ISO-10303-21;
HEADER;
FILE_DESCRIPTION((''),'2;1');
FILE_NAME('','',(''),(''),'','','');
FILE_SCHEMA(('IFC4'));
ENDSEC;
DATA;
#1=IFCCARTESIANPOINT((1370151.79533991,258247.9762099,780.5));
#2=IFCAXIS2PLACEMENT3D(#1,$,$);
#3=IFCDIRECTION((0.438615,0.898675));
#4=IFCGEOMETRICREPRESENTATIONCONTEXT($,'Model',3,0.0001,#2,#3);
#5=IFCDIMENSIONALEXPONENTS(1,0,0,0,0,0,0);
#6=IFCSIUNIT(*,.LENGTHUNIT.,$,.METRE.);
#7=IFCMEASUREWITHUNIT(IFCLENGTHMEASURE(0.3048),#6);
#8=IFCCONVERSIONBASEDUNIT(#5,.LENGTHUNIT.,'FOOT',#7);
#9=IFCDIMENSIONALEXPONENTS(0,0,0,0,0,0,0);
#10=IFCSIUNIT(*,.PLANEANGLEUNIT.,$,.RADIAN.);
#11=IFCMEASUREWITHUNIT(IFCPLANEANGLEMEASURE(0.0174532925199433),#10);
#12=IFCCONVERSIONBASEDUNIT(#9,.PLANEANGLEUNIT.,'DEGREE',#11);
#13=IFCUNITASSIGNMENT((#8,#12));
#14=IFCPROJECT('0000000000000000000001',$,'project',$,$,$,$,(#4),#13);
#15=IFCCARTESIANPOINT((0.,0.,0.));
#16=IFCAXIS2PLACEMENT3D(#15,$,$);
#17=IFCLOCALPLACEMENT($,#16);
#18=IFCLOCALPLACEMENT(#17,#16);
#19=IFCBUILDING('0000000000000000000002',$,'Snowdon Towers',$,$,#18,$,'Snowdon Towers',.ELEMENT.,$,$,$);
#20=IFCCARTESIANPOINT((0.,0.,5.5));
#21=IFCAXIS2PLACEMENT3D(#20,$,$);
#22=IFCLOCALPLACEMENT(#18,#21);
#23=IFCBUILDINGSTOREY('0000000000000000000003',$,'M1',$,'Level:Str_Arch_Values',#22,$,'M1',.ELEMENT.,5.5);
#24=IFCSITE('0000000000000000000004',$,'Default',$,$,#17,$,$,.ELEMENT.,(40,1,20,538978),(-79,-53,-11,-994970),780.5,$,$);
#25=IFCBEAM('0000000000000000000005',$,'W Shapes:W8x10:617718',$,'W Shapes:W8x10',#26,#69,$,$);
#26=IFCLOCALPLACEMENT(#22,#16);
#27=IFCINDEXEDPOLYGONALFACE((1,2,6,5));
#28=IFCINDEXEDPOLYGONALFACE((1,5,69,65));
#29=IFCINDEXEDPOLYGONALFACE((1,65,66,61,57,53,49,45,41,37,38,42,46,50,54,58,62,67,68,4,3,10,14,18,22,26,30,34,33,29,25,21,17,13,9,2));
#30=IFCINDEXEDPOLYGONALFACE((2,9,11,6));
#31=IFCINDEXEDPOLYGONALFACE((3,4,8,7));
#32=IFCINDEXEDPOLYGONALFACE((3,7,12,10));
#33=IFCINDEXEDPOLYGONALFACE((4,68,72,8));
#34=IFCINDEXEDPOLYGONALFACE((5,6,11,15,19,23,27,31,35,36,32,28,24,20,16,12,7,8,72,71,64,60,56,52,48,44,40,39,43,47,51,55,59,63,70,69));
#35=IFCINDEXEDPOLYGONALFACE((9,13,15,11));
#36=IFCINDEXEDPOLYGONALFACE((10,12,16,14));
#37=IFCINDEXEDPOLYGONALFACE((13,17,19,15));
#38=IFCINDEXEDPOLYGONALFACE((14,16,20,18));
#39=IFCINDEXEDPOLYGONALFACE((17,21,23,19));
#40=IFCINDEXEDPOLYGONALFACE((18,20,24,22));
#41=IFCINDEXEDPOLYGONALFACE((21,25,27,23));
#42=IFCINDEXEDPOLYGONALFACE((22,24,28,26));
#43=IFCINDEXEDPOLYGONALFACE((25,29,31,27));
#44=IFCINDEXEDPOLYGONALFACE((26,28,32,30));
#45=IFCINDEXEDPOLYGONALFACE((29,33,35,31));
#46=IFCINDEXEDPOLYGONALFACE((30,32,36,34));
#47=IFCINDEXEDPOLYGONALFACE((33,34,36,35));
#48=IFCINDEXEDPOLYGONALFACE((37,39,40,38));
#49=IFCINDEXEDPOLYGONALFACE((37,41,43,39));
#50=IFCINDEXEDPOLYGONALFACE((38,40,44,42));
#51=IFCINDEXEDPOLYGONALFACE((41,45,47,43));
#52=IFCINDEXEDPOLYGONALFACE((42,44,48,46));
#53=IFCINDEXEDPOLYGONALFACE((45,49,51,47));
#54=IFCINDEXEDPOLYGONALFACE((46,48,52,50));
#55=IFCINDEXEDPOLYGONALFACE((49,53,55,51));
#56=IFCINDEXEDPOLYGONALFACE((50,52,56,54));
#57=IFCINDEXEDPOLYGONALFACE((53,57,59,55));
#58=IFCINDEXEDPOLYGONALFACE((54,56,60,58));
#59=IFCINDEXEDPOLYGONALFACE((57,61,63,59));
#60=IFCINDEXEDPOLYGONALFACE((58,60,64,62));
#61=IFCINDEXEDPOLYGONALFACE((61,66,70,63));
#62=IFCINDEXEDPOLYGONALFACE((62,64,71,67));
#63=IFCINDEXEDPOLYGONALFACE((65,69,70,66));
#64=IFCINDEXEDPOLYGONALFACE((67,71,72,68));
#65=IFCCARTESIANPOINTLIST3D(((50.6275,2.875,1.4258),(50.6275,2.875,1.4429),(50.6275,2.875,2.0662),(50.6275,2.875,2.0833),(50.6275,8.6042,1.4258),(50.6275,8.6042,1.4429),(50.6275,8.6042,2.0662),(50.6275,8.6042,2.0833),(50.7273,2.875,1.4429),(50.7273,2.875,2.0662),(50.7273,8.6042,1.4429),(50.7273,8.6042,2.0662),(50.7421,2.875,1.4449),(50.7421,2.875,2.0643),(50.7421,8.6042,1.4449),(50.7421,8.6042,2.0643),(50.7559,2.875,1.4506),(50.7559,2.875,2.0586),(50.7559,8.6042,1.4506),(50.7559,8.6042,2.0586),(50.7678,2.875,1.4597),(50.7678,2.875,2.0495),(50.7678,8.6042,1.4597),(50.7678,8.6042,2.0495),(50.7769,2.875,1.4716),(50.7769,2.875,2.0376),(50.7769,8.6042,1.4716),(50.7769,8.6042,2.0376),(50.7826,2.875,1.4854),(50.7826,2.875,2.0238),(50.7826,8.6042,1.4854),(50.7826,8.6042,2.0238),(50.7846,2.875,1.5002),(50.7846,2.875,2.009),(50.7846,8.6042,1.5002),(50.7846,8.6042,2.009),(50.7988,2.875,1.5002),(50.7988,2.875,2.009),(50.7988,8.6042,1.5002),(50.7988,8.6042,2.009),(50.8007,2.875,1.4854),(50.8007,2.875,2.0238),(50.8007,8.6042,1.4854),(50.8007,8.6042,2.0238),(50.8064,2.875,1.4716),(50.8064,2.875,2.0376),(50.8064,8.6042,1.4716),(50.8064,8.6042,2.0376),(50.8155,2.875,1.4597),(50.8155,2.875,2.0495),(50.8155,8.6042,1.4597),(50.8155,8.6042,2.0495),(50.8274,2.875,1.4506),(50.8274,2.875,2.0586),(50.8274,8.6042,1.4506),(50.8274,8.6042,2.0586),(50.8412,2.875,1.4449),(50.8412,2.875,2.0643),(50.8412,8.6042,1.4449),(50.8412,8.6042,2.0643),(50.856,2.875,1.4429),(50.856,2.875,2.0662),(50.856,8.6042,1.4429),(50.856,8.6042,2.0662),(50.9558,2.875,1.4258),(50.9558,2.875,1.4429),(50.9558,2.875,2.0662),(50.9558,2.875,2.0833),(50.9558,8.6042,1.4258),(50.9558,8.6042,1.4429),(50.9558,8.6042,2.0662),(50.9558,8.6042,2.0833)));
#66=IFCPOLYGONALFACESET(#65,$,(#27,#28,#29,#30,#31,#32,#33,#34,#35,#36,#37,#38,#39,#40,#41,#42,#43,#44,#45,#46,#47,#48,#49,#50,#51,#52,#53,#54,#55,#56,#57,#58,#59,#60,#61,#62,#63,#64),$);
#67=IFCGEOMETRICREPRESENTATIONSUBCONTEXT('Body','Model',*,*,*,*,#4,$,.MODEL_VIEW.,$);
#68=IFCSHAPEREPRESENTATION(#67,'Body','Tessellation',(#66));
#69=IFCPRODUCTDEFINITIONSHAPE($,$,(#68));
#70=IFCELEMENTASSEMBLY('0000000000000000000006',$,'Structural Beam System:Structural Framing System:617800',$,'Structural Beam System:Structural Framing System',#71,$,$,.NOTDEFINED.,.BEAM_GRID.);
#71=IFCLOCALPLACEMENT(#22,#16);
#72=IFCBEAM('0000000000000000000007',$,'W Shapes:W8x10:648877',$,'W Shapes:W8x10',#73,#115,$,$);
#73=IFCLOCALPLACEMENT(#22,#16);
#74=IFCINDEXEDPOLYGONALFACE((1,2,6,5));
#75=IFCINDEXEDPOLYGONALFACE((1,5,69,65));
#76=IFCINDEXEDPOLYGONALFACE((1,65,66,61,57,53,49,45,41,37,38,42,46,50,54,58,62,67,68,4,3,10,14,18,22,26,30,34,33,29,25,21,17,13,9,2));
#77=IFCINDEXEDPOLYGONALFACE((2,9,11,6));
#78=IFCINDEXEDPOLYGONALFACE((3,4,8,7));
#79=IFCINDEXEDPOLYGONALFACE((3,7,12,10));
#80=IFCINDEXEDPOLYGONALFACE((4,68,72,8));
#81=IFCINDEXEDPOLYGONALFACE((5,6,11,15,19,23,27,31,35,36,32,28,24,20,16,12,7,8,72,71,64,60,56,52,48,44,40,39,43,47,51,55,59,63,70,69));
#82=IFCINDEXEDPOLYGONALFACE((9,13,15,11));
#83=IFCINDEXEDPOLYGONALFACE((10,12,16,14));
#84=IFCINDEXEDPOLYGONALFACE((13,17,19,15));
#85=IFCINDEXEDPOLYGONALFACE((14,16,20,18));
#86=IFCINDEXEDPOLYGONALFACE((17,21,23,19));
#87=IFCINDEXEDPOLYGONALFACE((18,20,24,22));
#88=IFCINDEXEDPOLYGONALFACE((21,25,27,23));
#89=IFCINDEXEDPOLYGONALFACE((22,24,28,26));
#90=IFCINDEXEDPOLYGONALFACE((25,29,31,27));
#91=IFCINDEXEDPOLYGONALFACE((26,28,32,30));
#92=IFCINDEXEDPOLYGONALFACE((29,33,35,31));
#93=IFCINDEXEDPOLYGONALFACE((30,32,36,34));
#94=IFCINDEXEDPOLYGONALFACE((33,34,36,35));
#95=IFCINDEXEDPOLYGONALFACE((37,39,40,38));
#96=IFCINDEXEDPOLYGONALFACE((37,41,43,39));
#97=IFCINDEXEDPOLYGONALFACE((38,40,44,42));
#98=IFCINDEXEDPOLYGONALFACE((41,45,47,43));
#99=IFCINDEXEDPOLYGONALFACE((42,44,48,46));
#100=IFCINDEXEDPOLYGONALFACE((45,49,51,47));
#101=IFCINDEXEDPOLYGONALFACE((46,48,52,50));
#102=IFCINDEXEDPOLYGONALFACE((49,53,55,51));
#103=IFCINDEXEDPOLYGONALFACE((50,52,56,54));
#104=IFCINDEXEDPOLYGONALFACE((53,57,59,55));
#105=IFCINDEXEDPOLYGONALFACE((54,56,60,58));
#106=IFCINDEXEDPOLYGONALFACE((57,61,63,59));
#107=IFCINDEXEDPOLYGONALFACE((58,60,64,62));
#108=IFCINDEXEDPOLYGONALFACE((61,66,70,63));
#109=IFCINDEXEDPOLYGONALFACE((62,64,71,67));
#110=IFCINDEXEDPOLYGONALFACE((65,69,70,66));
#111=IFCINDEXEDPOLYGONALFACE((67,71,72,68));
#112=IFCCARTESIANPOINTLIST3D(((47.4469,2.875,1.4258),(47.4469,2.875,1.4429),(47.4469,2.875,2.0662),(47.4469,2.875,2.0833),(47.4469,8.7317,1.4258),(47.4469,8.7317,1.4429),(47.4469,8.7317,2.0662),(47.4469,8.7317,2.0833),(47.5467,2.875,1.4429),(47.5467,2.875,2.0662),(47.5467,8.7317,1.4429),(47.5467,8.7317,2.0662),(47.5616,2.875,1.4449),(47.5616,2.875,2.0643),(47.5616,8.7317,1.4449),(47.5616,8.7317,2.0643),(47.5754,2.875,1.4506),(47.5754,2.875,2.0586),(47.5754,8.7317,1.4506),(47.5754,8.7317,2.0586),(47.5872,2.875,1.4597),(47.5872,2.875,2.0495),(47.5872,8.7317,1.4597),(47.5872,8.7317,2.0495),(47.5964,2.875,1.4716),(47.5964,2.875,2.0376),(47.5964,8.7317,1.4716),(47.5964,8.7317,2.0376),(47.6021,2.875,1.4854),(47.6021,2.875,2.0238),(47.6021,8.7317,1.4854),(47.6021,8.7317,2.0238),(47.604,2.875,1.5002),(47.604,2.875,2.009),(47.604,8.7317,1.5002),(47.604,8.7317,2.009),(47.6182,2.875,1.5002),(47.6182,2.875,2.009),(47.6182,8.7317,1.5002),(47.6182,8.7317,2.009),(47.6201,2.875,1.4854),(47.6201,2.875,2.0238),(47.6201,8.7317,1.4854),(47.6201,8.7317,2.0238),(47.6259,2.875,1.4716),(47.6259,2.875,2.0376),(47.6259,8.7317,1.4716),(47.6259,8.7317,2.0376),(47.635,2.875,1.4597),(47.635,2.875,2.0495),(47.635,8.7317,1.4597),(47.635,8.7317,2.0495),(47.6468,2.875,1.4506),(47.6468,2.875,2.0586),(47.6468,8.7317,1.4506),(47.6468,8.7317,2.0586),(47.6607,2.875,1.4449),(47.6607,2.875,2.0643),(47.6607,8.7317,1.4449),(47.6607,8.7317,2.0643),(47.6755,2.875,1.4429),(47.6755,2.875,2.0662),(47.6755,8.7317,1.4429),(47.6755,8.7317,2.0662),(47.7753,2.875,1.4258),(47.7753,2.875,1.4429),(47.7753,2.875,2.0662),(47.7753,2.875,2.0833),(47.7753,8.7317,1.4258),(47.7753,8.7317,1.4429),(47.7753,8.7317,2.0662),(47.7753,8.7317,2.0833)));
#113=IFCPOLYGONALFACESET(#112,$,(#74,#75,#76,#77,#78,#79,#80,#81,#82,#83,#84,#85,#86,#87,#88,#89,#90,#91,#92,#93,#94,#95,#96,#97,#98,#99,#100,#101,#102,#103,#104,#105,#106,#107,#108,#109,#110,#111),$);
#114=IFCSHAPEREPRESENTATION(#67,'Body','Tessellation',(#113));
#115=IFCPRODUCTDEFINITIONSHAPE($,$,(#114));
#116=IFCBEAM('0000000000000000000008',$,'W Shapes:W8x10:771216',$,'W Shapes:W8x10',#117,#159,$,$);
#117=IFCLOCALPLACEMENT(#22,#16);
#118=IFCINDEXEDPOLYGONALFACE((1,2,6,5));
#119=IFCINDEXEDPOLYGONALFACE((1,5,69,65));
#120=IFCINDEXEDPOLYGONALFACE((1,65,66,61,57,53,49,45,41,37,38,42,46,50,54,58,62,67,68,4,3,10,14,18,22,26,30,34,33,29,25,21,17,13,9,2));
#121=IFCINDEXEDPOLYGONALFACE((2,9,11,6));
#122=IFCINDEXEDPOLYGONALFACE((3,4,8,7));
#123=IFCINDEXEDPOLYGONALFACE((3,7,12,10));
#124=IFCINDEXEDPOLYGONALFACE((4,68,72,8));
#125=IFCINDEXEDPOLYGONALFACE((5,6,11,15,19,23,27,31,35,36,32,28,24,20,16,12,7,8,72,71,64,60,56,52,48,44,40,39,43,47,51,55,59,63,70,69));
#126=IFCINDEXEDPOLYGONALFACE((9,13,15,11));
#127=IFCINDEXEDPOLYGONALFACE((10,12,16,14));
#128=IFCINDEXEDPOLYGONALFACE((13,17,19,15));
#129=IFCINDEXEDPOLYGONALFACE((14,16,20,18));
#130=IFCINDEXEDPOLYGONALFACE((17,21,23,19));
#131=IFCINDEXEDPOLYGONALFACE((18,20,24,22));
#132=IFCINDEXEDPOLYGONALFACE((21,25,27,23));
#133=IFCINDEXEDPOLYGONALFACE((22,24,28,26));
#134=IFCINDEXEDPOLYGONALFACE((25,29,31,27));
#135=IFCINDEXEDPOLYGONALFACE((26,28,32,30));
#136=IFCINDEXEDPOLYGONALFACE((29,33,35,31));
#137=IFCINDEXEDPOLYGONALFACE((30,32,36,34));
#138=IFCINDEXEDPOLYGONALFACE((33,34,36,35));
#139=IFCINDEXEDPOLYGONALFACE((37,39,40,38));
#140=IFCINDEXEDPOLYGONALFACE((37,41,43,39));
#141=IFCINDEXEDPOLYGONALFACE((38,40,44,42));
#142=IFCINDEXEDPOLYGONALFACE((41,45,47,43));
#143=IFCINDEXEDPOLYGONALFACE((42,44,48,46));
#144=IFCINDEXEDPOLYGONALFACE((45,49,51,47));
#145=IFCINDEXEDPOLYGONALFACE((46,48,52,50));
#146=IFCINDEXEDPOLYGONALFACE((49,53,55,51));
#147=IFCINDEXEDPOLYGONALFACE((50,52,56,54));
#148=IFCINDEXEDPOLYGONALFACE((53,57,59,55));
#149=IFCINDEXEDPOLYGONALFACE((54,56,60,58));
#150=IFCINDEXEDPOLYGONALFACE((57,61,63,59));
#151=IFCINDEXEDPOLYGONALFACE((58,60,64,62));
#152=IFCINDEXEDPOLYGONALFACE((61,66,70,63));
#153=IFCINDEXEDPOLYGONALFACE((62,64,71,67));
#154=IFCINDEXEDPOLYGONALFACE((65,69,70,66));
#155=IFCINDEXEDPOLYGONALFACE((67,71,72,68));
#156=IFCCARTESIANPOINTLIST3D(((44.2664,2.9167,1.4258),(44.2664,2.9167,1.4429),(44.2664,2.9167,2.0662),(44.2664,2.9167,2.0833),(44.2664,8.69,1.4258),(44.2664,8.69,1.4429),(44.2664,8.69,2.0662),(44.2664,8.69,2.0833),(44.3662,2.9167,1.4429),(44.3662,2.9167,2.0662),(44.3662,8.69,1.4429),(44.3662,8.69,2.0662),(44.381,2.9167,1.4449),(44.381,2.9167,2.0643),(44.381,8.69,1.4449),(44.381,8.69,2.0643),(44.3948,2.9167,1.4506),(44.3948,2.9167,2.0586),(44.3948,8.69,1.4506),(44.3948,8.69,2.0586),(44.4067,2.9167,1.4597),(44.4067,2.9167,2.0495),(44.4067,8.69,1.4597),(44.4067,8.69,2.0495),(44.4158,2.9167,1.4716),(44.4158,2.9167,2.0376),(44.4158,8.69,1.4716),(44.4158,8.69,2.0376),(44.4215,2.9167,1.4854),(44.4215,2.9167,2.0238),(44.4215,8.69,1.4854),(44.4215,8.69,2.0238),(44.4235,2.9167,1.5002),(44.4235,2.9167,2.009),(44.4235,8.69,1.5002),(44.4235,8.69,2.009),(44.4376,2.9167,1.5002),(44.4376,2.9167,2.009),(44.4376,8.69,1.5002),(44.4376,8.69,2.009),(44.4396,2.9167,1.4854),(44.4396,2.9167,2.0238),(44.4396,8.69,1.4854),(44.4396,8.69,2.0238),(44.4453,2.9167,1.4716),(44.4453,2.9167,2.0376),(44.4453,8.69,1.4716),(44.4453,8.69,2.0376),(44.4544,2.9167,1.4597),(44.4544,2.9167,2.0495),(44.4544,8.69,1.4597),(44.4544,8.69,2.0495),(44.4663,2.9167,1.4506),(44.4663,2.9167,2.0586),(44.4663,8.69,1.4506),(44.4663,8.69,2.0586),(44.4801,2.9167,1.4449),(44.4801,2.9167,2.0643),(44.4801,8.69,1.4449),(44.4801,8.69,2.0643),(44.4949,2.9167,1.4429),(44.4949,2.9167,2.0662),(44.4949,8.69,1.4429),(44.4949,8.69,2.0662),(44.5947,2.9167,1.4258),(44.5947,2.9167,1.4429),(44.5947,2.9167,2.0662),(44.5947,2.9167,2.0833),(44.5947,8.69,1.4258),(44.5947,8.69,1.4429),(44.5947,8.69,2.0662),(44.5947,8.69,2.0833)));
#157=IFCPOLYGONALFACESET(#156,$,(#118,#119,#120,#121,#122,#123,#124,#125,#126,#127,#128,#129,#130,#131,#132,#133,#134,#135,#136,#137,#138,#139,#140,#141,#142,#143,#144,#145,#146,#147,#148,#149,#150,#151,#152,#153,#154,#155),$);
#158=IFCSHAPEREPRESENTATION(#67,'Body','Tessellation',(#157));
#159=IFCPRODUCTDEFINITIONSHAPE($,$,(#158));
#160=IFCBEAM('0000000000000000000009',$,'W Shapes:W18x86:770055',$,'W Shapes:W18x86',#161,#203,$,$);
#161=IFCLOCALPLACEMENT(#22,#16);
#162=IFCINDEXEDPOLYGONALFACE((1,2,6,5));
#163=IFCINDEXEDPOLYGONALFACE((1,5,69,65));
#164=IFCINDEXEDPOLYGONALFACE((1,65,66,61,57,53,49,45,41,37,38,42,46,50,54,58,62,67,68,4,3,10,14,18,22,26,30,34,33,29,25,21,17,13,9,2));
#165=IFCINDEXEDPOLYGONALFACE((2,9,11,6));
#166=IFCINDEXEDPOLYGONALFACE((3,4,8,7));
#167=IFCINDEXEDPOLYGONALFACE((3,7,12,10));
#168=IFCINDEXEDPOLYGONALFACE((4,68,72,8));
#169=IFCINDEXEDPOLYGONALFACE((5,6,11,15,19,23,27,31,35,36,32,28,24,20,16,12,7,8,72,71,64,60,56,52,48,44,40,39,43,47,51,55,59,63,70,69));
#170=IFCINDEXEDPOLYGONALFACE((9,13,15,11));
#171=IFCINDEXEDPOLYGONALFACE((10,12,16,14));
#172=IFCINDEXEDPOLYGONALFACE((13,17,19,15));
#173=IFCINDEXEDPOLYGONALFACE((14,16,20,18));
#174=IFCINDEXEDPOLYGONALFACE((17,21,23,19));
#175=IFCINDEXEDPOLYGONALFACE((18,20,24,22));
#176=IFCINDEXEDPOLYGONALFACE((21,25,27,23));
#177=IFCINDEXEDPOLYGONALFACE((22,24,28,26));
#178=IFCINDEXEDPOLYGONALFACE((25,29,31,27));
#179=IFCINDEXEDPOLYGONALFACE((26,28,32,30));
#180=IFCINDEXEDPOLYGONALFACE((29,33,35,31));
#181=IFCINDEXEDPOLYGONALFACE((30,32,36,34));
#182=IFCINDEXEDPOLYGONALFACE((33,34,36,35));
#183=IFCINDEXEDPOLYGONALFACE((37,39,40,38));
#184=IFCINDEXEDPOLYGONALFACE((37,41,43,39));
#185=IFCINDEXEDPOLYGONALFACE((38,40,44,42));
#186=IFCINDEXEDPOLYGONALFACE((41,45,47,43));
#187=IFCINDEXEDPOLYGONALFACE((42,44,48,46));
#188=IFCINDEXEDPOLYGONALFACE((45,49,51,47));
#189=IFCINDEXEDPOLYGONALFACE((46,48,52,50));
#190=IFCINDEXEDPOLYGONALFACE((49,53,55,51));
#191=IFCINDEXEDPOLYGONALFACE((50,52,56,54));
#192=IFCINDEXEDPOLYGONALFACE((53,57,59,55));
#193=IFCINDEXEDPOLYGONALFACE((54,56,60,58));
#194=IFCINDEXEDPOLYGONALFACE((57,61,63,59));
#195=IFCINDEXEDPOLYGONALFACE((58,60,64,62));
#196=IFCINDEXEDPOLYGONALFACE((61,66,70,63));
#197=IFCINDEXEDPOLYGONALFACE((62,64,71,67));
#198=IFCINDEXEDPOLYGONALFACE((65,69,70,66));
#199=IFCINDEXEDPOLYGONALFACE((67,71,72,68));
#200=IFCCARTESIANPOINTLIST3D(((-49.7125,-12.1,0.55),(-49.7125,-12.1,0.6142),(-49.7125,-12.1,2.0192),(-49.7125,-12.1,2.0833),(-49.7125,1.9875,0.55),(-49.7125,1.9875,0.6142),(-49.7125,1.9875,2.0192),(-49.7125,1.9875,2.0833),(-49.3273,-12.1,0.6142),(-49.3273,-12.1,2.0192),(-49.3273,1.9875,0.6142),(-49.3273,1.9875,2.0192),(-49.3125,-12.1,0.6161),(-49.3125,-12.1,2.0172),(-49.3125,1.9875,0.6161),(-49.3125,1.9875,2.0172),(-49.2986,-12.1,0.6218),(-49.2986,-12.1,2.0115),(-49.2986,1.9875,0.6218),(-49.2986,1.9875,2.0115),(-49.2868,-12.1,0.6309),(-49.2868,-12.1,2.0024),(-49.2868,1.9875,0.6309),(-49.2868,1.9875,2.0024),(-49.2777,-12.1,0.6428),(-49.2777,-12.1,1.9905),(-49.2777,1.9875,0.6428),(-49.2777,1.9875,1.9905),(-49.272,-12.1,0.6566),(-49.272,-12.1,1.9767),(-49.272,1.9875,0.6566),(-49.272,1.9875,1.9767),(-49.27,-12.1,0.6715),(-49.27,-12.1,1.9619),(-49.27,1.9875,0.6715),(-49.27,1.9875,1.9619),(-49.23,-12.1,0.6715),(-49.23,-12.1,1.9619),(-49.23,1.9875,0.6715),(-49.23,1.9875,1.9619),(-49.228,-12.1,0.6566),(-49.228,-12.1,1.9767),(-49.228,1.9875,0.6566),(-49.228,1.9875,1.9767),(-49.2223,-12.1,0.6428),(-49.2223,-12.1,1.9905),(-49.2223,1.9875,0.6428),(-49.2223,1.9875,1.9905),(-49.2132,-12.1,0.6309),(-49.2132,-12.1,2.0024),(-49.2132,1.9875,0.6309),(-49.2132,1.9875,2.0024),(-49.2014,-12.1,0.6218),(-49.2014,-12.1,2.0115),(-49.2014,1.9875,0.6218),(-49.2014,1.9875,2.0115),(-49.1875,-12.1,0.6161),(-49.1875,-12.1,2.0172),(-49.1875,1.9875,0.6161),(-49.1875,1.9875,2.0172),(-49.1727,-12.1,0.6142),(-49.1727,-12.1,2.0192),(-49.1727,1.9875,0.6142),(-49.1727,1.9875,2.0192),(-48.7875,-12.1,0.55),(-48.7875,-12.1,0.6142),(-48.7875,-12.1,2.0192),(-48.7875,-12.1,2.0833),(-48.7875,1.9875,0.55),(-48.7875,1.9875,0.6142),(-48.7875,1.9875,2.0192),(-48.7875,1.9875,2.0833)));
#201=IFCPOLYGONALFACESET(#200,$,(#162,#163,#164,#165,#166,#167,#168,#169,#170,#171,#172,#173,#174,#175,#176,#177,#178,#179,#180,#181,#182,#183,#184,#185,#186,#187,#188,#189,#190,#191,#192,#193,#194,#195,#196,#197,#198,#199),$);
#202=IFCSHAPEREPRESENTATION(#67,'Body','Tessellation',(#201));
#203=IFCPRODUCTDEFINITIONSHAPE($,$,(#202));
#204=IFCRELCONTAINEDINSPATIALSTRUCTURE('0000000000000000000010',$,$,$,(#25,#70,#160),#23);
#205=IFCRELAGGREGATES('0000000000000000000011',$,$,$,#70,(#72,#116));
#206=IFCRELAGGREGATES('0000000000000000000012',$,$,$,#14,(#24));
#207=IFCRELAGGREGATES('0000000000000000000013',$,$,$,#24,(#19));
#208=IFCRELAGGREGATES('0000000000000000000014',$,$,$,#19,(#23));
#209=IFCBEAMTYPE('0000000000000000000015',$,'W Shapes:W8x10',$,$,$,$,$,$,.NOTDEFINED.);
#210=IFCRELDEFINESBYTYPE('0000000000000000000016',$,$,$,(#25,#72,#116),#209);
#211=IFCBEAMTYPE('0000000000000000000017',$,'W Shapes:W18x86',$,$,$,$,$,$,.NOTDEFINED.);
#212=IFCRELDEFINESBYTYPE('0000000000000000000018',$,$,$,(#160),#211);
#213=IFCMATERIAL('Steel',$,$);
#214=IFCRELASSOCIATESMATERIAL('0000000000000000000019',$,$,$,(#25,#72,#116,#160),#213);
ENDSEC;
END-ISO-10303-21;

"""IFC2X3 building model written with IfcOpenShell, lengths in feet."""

from ifc_helpers import new_model, entity, si_unit, converted_unit, direction, frame, frame_2d, origin, place, context, subcontext, project, spatial, i_section, extrude, material, type_object, element, aggregate, save


model = new_model("IFC2X3")

# Units and contexts
model_context = context("Model", 3, precision=0.0001, world=frame((1370151.79533991, 258247.9762099, 780.5)), true_north=direction((0.438615, 0.898675)))
body_context = subcontext(model_context, "Body", "Model", "MODEL_VIEW")
ifc_project = project(units=[converted_unit("LENGTHUNIT", "FOOT", entity("IfcLengthMeasure", 0.3048), si_unit("LENGTHUNIT", "METRE"), dimensions=[1, 0, 0, 0, 0, 0, 0]), converted_unit("PLANEANGLEUNIT", "DEGREE", entity("IfcPlaneAngleMeasure", 0.0174532925199433), si_unit("PLANEANGLEUNIT", "RADIAN"), dimensions=[0, 0, 0, 0, 0, 0, 0])], contexts=[model_context])

# Site, building, storey
site_placement = place(None, origin())
site = spatial("IfcSite", under=ifc_project, at=site_placement, Name="Default", CompositionType="ELEMENT", RefLatitude=(40, 1, 20, 538978), RefLongitude=(-79, -53, -11, -994970), RefElevation=780.5)
building_placement = place(site_placement, origin())
building = spatial("IfcBuilding", under=site, at=building_placement, Name="Snowdon Towers", LongName="Snowdon Towers", CompositionType="ELEMENT")
storey_placement = place(building_placement, frame((0.0, 0.0, 5.5)))
storey = spatial("IfcBuildingStorey", under=building, at=storey_placement, Name="M1", ObjectType="Level:Str_Arch_Values", LongName="M1", CompositionType="ELEMENT", Elevation=5.5)

# Beam
ifc_material_1 = material(Name="Steel")
beam_type_1 = type_object("IfcBeamType", Name="W Shapes:W8x10", PredefinedType="NOTDEFINED")
beam_1_placement = place(storey_placement, frame((50.7917, 9.0, 2.0833), z_axis=(0.0, 0.0, 1.0), x_axis=(0.0, -1.0, 0.0)))
element("IfcBeam", 1, at=beam_1_placement, inside=storey, type_object=beam_type_1, material=ifc_material_1, Name="W Shapes:W8x10:617718", ObjectType="W Shapes:W8x10", context=body_context, shape_type="SweptSolid", body=[
    extrude(i_section(OverallWidth=0.3283, OverallDepth=0.6575, WebThickness=0.0142, FlangeThickness=0.0171, FilletRadius=0.0573, at=frame_2d((0.0, 0.0), x_axis=(0.0, 1.0))), frame((0.3958, 0.0, -0.3288), z_axis=(1.0, 0.0, 0.0), x_axis=(0.0, 0.0, -1.0)), (0.0, 0.0, 1.0), 5.7292),
])

# Element assembly, beams
assembly_placement = place(storey_placement, origin())
assembly = element("IfcElementAssembly", 2, at=assembly_placement, inside=storey, Name="Structural Beam System:Structural Framing System:617800", ObjectType="Structural Beam System:Structural Framing System", AssemblyPlace="NOTDEFINED", PredefinedType="BEAM_GRID")
beam_2_placement = place(assembly_placement, frame((47.6111, 8.8958, 2.0833), z_axis=(0.0, 0.0, 1.0), x_axis=(0.0, -1.0, 0.0)))
beam_2 = element("IfcBeam", 3, at=beam_2_placement, type_object=beam_type_1, material=ifc_material_1, Name="W Shapes:W8x10:648877", ObjectType="W Shapes:W8x10", context=body_context, shape_type="SweptSolid", body=[
    extrude(i_section(OverallWidth=0.3283, OverallDepth=0.6575, WebThickness=0.0142, FlangeThickness=0.0171, FilletRadius=0.0573, at=frame_2d((0.0, 0.0), x_axis=(0.0, 1.0))), frame((0.1642, 0.0, -0.3288), z_axis=(1.0, 0.0, 0.0), x_axis=(0.0, 0.0, -1.0)), (0.0, 0.0, 1.0), 5.8567),
])
beam_3_placement = place(assembly_placement, frame((44.4306, 8.8958, 2.0833), z_axis=(0.0, 0.0, 1.0), x_axis=(0.0, -1.0, 0.0)))
beam_3 = element("IfcBeam", 4, at=beam_3_placement, type_object=beam_type_1, material=ifc_material_1, Name="W Shapes:W8x10:771216", ObjectType="W Shapes:W8x10", context=body_context, shape_type="SweptSolid", body=[
    extrude(i_section(OverallWidth=0.3283, OverallDepth=0.6575, WebThickness=0.0142, FlangeThickness=0.0171, FilletRadius=0.0573, at=frame_2d((0.0, 0.0), x_axis=(0.0, 1.0))), frame((0.2058, 0.0, -0.3288), z_axis=(1.0, 0.0, 0.0), x_axis=(0.0, 0.0, -1.0)), (0.0, 0.0, 1.0), 5.7733),
])
aggregate(assembly, [beam_2, beam_3])

# Beam
beam_type_2 = type_object("IfcBeamType", Name="W Shapes:W18x86", PredefinedType="NOTDEFINED")
beam_4_placement = place(storey_placement, frame((-49.25, 2.5, 2.0833), z_axis=(0.0, 0.0, 1.0), x_axis=(0.0, -1.0, 0.0)))
element("IfcBeam", 5, at=beam_4_placement, inside=storey, type_object=beam_type_2, material=ifc_material_1, Name="W Shapes:W18x86:770055", ObjectType="W Shapes:W18x86", context=body_context, shape_type="SweptSolid", body=[
    extrude(i_section(OverallWidth=0.925, OverallDepth=1.5333, WebThickness=0.04, FlangeThickness=0.0642, FilletRadius=0.0573, at=frame_2d((0.0, 0.0), x_axis=(0.0, 1.0))), frame((0.5125, 0.0, -0.7667), z_axis=(1.0, 0.0, 0.0), x_axis=(0.0, 0.0, -1.0)), (0.0, 0.0, 1.0), 14.0875),
])

save(model, "model.ifc")
